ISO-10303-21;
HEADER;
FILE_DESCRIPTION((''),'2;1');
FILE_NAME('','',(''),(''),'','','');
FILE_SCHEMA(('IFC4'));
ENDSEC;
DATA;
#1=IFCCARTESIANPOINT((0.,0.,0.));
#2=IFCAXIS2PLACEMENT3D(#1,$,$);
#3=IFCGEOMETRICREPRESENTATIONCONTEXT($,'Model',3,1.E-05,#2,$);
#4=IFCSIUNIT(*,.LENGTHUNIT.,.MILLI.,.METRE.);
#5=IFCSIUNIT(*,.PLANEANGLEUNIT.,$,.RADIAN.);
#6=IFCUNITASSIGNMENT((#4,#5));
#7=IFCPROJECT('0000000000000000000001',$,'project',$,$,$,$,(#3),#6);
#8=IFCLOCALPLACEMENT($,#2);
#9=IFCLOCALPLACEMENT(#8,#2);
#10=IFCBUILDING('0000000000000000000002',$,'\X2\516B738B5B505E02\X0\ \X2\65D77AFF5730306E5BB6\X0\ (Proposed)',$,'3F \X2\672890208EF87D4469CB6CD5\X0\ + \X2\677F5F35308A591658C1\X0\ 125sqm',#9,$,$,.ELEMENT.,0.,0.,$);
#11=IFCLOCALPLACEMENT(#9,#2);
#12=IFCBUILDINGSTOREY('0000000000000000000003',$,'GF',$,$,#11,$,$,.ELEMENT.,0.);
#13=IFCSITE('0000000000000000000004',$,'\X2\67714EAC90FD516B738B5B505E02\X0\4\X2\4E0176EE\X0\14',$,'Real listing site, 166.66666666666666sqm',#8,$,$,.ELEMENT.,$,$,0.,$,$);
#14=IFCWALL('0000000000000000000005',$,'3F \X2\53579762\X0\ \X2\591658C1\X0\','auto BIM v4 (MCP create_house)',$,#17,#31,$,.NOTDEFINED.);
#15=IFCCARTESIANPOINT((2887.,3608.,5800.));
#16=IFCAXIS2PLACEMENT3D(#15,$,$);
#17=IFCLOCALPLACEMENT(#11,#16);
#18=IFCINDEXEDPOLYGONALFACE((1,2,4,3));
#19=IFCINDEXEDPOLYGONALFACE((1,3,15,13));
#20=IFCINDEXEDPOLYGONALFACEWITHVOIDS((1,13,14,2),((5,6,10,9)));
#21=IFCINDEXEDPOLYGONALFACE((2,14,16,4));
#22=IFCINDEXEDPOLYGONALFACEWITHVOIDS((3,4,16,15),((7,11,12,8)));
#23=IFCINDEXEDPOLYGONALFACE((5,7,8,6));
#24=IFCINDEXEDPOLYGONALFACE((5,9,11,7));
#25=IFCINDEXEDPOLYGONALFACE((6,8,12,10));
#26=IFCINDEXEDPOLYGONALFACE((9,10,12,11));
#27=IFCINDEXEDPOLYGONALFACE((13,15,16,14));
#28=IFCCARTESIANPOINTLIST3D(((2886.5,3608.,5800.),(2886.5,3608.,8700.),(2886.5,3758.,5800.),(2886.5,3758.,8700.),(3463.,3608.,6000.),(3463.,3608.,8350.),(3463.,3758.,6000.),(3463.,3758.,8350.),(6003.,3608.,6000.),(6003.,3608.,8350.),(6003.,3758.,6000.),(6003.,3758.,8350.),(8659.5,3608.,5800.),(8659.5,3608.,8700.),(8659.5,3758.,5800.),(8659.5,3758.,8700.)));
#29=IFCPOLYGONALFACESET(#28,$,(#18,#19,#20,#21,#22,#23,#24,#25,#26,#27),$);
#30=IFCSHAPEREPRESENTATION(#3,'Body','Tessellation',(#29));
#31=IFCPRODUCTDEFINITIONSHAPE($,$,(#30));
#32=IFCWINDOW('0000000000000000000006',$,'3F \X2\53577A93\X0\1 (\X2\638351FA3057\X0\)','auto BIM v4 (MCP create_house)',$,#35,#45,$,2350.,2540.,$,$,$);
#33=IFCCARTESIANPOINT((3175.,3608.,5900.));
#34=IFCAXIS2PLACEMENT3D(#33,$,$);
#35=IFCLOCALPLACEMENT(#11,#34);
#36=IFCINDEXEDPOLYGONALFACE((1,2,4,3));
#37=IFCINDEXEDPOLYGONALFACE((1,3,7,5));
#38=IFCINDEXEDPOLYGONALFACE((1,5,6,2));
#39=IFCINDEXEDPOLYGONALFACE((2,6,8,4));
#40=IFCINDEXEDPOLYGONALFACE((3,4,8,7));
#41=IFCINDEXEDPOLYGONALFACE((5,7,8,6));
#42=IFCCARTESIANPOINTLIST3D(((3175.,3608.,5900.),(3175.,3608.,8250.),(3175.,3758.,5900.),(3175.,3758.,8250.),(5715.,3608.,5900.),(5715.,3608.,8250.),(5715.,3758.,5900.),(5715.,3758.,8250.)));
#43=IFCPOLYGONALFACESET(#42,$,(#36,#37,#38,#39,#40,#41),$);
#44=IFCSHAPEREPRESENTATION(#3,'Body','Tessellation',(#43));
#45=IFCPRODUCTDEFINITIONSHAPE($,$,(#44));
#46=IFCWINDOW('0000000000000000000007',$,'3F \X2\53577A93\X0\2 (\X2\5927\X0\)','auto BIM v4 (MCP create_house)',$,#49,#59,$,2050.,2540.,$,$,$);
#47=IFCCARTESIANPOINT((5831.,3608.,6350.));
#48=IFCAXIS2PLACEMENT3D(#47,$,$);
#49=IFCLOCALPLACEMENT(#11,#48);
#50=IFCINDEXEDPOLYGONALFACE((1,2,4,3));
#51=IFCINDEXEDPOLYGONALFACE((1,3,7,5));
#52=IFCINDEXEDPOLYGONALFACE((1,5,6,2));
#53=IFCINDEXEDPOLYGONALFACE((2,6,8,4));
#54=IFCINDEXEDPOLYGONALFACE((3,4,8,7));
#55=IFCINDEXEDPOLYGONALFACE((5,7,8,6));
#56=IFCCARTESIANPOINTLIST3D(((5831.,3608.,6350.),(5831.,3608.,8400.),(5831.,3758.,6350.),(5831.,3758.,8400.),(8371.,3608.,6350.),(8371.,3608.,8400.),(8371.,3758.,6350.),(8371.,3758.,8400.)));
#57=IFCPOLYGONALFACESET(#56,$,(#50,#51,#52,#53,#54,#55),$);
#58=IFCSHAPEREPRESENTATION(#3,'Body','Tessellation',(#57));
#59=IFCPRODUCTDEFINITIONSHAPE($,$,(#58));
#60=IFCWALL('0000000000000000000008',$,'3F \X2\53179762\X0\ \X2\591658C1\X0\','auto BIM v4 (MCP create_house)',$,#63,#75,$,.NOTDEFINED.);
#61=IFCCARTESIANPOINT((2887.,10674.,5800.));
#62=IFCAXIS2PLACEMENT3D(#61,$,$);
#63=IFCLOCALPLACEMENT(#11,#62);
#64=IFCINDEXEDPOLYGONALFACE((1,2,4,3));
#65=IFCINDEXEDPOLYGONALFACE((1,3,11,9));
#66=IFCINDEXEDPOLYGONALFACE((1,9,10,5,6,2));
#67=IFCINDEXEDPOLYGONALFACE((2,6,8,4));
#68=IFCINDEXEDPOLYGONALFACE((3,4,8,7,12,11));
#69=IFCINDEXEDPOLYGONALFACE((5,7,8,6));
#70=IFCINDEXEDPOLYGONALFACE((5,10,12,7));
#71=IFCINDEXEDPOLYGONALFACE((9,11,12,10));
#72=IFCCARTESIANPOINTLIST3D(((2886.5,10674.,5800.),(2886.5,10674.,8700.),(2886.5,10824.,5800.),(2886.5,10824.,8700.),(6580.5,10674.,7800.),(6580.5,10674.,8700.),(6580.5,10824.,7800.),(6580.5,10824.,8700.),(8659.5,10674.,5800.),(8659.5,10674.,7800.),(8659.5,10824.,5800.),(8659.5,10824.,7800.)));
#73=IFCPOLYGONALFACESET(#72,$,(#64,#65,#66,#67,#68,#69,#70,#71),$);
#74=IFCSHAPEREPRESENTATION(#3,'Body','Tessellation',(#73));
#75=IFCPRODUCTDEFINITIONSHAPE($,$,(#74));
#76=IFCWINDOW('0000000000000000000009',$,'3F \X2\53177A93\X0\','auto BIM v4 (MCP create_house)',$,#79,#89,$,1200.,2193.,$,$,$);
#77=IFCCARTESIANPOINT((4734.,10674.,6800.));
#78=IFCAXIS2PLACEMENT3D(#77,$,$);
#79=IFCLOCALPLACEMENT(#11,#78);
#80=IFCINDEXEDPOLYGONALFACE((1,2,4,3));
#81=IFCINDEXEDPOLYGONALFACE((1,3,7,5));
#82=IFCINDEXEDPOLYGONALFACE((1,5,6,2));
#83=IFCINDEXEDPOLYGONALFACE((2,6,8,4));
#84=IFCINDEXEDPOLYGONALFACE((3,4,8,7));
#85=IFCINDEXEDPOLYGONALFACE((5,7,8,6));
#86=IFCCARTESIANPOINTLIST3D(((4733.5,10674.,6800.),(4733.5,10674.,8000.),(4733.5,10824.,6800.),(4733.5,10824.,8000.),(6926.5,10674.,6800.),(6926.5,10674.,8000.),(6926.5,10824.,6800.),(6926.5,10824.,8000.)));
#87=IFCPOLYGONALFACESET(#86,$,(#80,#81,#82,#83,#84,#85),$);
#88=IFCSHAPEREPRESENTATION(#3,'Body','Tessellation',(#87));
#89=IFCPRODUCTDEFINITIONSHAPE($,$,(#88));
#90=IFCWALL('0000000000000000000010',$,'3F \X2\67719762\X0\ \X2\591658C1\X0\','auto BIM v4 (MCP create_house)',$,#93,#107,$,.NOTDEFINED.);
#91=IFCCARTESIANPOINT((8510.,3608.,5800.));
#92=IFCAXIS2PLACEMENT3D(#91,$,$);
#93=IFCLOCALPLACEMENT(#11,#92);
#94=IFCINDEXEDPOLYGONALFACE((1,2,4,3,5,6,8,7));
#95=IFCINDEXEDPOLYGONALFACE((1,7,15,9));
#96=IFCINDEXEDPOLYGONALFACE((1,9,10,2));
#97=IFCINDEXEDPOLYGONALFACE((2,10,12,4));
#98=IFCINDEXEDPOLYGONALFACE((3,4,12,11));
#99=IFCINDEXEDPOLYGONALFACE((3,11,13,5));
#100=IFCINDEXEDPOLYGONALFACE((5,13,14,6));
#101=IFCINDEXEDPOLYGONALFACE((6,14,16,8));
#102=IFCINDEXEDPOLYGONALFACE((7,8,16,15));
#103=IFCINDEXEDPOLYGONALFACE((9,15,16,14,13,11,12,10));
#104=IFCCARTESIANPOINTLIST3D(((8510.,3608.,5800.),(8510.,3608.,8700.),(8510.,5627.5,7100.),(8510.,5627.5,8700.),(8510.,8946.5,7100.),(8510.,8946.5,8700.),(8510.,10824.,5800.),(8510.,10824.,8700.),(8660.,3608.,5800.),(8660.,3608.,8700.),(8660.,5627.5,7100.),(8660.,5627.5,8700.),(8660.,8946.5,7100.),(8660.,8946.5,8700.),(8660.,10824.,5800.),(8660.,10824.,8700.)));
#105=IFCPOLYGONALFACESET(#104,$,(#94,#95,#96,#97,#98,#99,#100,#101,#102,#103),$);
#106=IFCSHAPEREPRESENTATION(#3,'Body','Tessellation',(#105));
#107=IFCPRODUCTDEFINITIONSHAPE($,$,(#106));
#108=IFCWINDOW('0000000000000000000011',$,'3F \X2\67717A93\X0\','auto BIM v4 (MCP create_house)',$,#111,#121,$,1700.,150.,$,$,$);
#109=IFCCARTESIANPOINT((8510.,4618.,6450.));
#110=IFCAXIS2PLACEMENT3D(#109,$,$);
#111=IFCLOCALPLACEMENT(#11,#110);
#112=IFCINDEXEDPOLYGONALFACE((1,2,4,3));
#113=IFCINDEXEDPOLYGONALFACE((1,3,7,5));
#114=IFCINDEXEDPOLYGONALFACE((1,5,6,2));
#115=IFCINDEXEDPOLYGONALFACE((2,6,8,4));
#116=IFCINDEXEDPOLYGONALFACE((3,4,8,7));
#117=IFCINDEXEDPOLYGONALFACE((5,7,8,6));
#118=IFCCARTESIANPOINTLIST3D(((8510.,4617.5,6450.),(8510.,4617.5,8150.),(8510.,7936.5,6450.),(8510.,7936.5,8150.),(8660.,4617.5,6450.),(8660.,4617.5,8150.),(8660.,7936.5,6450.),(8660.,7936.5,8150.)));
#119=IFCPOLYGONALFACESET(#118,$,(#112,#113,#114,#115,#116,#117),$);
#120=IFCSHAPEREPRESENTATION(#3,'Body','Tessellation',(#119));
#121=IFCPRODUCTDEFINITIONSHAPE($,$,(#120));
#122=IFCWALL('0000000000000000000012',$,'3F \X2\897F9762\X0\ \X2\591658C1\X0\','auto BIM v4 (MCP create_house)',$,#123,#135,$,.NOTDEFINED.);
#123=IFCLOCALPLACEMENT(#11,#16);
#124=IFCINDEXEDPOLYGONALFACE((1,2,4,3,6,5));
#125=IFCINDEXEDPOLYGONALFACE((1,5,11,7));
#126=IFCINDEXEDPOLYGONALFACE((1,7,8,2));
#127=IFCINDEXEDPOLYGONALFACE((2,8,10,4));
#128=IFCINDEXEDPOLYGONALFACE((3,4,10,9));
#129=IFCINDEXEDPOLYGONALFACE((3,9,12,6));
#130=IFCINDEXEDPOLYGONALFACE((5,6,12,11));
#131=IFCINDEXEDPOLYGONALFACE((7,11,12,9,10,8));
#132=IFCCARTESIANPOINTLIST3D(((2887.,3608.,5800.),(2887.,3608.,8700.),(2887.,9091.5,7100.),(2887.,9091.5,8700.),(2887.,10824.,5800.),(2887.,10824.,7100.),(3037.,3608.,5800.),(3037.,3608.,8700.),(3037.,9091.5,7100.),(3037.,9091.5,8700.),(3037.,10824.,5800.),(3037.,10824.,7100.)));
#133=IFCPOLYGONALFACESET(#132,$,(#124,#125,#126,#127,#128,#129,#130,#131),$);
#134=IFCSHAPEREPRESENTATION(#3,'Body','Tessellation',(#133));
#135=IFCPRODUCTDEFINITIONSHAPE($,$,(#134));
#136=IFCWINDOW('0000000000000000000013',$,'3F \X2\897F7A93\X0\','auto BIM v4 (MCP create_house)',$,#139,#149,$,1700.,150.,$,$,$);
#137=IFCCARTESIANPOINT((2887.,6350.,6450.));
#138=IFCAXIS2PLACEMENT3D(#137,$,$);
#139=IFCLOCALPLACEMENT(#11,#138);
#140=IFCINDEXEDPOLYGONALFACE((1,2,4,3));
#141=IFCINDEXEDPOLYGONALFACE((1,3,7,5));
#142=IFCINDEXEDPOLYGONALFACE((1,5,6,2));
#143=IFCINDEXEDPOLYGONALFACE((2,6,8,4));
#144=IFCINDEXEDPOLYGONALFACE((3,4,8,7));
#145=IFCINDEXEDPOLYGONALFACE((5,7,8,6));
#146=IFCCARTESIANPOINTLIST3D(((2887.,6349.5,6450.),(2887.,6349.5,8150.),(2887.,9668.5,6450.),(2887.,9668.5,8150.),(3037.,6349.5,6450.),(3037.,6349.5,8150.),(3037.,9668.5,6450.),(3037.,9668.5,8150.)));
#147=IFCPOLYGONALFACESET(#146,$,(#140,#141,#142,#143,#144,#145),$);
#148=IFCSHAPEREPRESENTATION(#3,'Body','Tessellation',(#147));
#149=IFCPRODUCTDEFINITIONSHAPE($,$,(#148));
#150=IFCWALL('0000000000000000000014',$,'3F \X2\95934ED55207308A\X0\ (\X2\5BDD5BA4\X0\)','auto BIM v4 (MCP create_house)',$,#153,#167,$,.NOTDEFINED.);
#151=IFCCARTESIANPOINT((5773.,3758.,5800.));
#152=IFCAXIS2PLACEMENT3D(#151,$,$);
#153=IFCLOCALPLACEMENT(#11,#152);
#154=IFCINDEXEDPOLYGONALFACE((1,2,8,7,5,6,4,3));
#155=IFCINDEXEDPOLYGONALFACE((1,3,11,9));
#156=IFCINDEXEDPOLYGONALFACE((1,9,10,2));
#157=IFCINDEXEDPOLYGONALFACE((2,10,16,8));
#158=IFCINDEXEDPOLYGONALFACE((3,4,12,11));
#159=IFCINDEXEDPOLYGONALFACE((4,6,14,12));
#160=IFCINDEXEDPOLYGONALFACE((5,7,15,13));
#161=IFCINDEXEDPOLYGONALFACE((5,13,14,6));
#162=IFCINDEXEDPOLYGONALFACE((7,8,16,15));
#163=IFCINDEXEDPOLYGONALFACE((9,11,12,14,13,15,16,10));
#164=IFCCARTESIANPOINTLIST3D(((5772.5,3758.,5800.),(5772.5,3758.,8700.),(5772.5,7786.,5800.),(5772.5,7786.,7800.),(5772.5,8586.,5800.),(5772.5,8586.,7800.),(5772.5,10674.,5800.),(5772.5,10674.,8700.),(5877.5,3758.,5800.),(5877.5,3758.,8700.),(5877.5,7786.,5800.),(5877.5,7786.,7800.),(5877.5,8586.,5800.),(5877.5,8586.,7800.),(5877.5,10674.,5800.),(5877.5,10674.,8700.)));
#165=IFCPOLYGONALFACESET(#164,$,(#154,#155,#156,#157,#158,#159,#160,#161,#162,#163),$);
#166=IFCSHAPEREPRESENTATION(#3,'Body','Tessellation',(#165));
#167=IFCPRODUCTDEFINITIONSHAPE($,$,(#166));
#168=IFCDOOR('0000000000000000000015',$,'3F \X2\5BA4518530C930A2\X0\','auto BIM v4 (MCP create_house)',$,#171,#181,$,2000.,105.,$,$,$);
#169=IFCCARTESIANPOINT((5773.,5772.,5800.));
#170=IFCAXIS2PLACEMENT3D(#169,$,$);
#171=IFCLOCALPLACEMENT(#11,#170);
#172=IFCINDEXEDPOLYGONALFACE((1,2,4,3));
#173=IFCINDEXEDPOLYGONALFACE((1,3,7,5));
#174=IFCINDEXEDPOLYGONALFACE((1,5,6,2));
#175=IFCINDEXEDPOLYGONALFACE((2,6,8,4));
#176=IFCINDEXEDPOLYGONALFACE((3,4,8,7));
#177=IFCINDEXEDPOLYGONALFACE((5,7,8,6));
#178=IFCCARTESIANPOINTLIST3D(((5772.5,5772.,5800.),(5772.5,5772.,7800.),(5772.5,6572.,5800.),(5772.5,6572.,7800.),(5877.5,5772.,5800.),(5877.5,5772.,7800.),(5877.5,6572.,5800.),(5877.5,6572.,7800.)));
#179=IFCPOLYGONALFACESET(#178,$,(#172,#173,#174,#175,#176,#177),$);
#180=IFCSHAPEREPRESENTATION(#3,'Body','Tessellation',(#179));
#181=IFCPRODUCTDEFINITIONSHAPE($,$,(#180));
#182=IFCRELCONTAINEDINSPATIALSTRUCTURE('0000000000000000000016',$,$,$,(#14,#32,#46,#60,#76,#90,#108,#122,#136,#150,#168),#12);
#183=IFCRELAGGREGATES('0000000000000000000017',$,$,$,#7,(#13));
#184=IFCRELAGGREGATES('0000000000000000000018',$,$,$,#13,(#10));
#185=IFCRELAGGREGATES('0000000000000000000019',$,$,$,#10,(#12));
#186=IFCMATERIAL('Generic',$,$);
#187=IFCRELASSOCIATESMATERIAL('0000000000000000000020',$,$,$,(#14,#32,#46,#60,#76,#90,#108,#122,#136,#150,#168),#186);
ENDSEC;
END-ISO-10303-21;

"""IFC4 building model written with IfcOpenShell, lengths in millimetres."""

from ifc_helpers import new_model, si_unit, frame, frame_2d, origin, place, context, project, spatial, rectangle, extrude, material, element, fill, save


model = new_model("IFC4")

# Units and contexts
model_context = context("Model", 3, precision=1e-05, world=origin())
ifc_project = project(units=[si_unit("LENGTHUNIT", "METRE", prefix="MILLI"), si_unit("PLANEANGLEUNIT", "RADIAN")], contexts=[model_context])

# Site, building, storey
site_placement = place(None, origin())
site = spatial("IfcSite", under=ifc_project, at=site_placement, Name="東京都八王子市4丁目14", ObjectType="Real listing site, 166.66666666666666sqm", CompositionType="ELEMENT", RefElevation=0.0)
building_placement = place(site_placement, origin())
building = spatial("IfcBuilding", under=site, at=building_placement, Name="八王子市 旗竿地の家 (Proposed)", ObjectType="3F 木造軸組構法 + 板張り外壁 125sqm", CompositionType="ELEMENT", ElevationOfRefHeight=0.0, ElevationOfTerrain=0.0)
storey_placement = place(building_placement, origin())
storey = spatial("IfcBuildingStorey", under=building, at=storey_placement, Name="GF", CompositionType="ELEMENT", Elevation=0.0)

# Shared definitions
ifc_material = material(Name="Generic")

# Wall, openings, windows
wall_1_placement = place(storey_placement, frame((2887.0, 3608.0, 5800.0)))
wall_1 = element("IfcWall", 1, at=wall_1_placement, inside=storey, material=ifc_material, Name="3F 南面 外壁", Description="auto BIM v4 (MCP create_house)", PredefinedType="NOTDEFINED", context=model_context, shape_type="SweptSolid", body=[
    extrude(rectangle(XDim=5773.0, YDim=150.0, at=frame_2d((2886.0, 75.0))), frame((2887.0, 3608.0, 5800.0)), (0.0, 0.0, 1.0), 2900.0),
])
opening_1_placement = place(storey_placement, frame((3175.0, 3608.0, 5900.0)))
opening_1 = element("IfcOpeningElement", 2, at=opening_1_placement, cuts=wall_1, PredefinedType="NOTDEFINED", context=model_context, shape_type="SweptSolid", body=[
    extrude(rectangle(XDim=2540.0, YDim=150.0, at=frame_2d((1270.0, 75.0))), frame((3175.0, 3608.0, 5900.0)), (0.0, 0.0, 1.0), 2350.0),
])
opening_2_placement = place(storey_placement, frame((5831.0, 3608.0, 6350.0)))
opening_2 = element("IfcOpeningElement", 3, at=opening_2_placement, cuts=wall_1, PredefinedType="NOTDEFINED", context=model_context, shape_type="SweptSolid", body=[
    extrude(rectangle(XDim=2540.0, YDim=150.0, at=frame_2d((1270.0, 75.0))), frame((5831.0, 3608.0, 6350.0)), (0.0, 0.0, 1.0), 2050.0),
])
window_1_placement = place(storey_placement, frame((3175.0, 3608.0, 5900.0)))
window_1 = element("IfcWindow", 4, at=window_1_placement, inside=storey, material=ifc_material, Name="3F 南窓1 (掃出し)", Description="auto BIM v4 (MCP create_house)", OverallHeight=2350.0, OverallWidth=2540.0, context=model_context, shape_type="SweptSolid", body=[
    extrude(rectangle(XDim=2540.0, YDim=150.0, at=frame_2d((1270.0, 75.0))), frame((3175.0, 3608.0, 5900.0)), (0.0, 0.0, 1.0), 2350.0),
])
fill(opening_1, window_1)
window_2_placement = place(storey_placement, frame((5831.0, 3608.0, 6350.0)))
window_2 = element("IfcWindow", 5, at=window_2_placement, inside=storey, material=ifc_material, Name="3F 南窓2 (大)", Description="auto BIM v4 (MCP create_house)", OverallHeight=2050.0, OverallWidth=2540.0, context=model_context, shape_type="SweptSolid", body=[
    extrude(rectangle(XDim=2540.0, YDim=150.0, at=frame_2d((1270.0, 75.0))), frame((5831.0, 3608.0, 6350.0)), (0.0, 0.0, 1.0), 2050.0),
])
fill(opening_2, window_2)

# Walls, openings, windows
wall_2_placement = place(storey_placement, frame((2887.0, 10674.0, 5800.0)))
wall_2 = element("IfcWall", 6, at=wall_2_placement, inside=storey, material=ifc_material, Name="3F 北面 外壁", Description="auto BIM v4 (MCP create_house)", PredefinedType="NOTDEFINED", context=model_context, shape_type="SweptSolid", body=[
    extrude(rectangle(XDim=5773.0, YDim=150.0, at=frame_2d((2886.0, 75.0))), frame((2887.0, 10674.0, 5800.0)), (0.0, 0.0, 1.0), 2900.0),
])
opening_3_placement = place(storey_placement, frame((4734.0, 10674.0, 6800.0)))
opening_3 = element("IfcOpeningElement", 7, at=opening_3_placement, cuts=wall_2, PredefinedType="NOTDEFINED", context=model_context, shape_type="SweptSolid", body=[
    extrude(rectangle(XDim=2193.0, YDim=150.0, at=frame_2d((1096.0, 75.0))), frame((4734.0, 10674.0, 6800.0)), (0.0, 0.0, 1.0), 1200.0),
])
window_3_placement = place(storey_placement, frame((4734.0, 10674.0, 6800.0)))
window_3 = element("IfcWindow", 8, at=window_3_placement, inside=storey, material=ifc_material, Name="3F 北窓", Description="auto BIM v4 (MCP create_house)", OverallHeight=1200.0, OverallWidth=2193.0, context=model_context, shape_type="SweptSolid", body=[
    extrude(rectangle(XDim=2193.0, YDim=150.0, at=frame_2d((1096.0, 75.0))), frame((4734.0, 10674.0, 6800.0)), (0.0, 0.0, 1.0), 1200.0),
])
fill(opening_3, window_3)
wall_3_placement = place(storey_placement, frame((8510.0, 3608.0, 5800.0)))
wall_3 = element("IfcWall", 9, at=wall_3_placement, inside=storey, material=ifc_material, Name="3F 東面 外壁", Description="auto BIM v4 (MCP create_house)", PredefinedType="NOTDEFINED", context=model_context, shape_type="SweptSolid", body=[
    extrude(rectangle(XDim=150.0, YDim=7216.0, at=frame_2d((75.0, 3608.0))), frame((8510.0, 3608.0, 5800.0)), (0.0, 0.0, 1.0), 2900.0),
])
opening_4_placement = place(storey_placement, frame((8510.0, 4618.0, 6450.0)))
opening_4 = element("IfcOpeningElement", 10, at=opening_4_placement, cuts=wall_3, PredefinedType="NOTDEFINED", context=model_context, shape_type="SweptSolid", body=[
    extrude(rectangle(XDim=150.0, YDim=3319.0, at=frame_2d((75.0, 1659.0))), frame((8510.0, 4618.0, 6450.0)), (0.0, 0.0, 1.0), 1700.0),
])
window_4_placement = place(storey_placement, frame((8510.0, 4618.0, 6450.0)))
window_4 = element("IfcWindow", 11, at=window_4_placement, inside=storey, material=ifc_material, Name="3F 東窓", Description="auto BIM v4 (MCP create_house)", OverallHeight=1700.0, OverallWidth=150.0, context=model_context, shape_type="SweptSolid", body=[
    extrude(rectangle(XDim=150.0, YDim=3319.0, at=frame_2d((75.0, 1659.0))), frame((8510.0, 4618.0, 6450.0)), (0.0, 0.0, 1.0), 1700.0),
])
fill(opening_4, window_4)
wall_4_placement = place(storey_placement, frame((2887.0, 3608.0, 5800.0)))
wall_4 = element("IfcWall", 12, at=wall_4_placement, inside=storey, material=ifc_material, Name="3F 西面 外壁", Description="auto BIM v4 (MCP create_house)", PredefinedType="NOTDEFINED", context=model_context, shape_type="SweptSolid", body=[
    extrude(rectangle(XDim=150.0, YDim=7216.0, at=frame_2d((75.0, 3608.0))), frame((2887.0, 3608.0, 5800.0)), (0.0, 0.0, 1.0), 2900.0),
])
opening_5_placement = place(storey_placement, frame((2887.0, 6350.0, 6450.0)))
opening_5 = element("IfcOpeningElement", 13, at=opening_5_placement, cuts=wall_4, PredefinedType="NOTDEFINED", context=model_context, shape_type="SweptSolid", body=[
    extrude(rectangle(XDim=150.0, YDim=3319.0, at=frame_2d((75.0, 1659.0))), frame((2887.0, 6350.0, 6450.0)), (0.0, 0.0, 1.0), 1700.0),
])
window_5_placement = place(storey_placement, frame((2887.0, 6350.0, 6450.0)))
window_5 = element("IfcWindow", 14, at=window_5_placement, inside=storey, material=ifc_material, Name="3F 西窓", Description="auto BIM v4 (MCP create_house)", OverallHeight=1700.0, OverallWidth=150.0, context=model_context, shape_type="SweptSolid", body=[
    extrude(rectangle(XDim=150.0, YDim=3319.0, at=frame_2d((75.0, 1659.0))), frame((2887.0, 6350.0, 6450.0)), (0.0, 0.0, 1.0), 1700.0),
])
fill(opening_5, window_5)

# Wall, opening, door
wall_5_placement = place(storey_placement, frame((5773.0, 3758.0, 5800.0)))
wall_5 = element("IfcWall", 15, at=wall_5_placement, inside=storey, material=ifc_material, Name="3F 間仕切り (寝室)", Description="auto BIM v4 (MCP create_house)", PredefinedType="NOTDEFINED", context=model_context, shape_type="SweptSolid", body=[
    extrude(rectangle(XDim=105.0, YDim=6916.0, at=frame_2d((52.0, 3458.0))), frame((5773.0, 3758.0, 5800.0)), (0.0, 0.0, 1.0), 2900.0),
])
opening_6_placement = place(storey_placement, frame((5773.0, 5772.0, 5800.0)))
opening_6 = element("IfcOpeningElement", 16, at=opening_6_placement, cuts=wall_5, PredefinedType="NOTDEFINED", context=model_context, shape_type="SweptSolid", body=[
    extrude(rectangle(XDim=105.0, YDim=800.0, at=frame_2d((52.0, 400.0))), frame((5773.0, 5772.0, 5800.0)), (0.0, 0.0, 1.0), 2000.0),
])
door_1_placement = place(storey_placement, frame((5773.0, 5772.0, 5800.0)))
door_1 = element("IfcDoor", 17, at=door_1_placement, inside=storey, material=ifc_material, Name="3F 室内ドア", Description="auto BIM v4 (MCP create_house)", OverallHeight=2000.0, OverallWidth=105.0, context=model_context, shape_type="SweptSolid", body=[
    extrude(rectangle(XDim=105.0, YDim=800.0, at=frame_2d((52.0, 400.0))), frame((5773.0, 5772.0, 5800.0)), (0.0, 0.0, 1.0), 2000.0),
])
fill(opening_6, door_1)

save(model, "model.ifc")
